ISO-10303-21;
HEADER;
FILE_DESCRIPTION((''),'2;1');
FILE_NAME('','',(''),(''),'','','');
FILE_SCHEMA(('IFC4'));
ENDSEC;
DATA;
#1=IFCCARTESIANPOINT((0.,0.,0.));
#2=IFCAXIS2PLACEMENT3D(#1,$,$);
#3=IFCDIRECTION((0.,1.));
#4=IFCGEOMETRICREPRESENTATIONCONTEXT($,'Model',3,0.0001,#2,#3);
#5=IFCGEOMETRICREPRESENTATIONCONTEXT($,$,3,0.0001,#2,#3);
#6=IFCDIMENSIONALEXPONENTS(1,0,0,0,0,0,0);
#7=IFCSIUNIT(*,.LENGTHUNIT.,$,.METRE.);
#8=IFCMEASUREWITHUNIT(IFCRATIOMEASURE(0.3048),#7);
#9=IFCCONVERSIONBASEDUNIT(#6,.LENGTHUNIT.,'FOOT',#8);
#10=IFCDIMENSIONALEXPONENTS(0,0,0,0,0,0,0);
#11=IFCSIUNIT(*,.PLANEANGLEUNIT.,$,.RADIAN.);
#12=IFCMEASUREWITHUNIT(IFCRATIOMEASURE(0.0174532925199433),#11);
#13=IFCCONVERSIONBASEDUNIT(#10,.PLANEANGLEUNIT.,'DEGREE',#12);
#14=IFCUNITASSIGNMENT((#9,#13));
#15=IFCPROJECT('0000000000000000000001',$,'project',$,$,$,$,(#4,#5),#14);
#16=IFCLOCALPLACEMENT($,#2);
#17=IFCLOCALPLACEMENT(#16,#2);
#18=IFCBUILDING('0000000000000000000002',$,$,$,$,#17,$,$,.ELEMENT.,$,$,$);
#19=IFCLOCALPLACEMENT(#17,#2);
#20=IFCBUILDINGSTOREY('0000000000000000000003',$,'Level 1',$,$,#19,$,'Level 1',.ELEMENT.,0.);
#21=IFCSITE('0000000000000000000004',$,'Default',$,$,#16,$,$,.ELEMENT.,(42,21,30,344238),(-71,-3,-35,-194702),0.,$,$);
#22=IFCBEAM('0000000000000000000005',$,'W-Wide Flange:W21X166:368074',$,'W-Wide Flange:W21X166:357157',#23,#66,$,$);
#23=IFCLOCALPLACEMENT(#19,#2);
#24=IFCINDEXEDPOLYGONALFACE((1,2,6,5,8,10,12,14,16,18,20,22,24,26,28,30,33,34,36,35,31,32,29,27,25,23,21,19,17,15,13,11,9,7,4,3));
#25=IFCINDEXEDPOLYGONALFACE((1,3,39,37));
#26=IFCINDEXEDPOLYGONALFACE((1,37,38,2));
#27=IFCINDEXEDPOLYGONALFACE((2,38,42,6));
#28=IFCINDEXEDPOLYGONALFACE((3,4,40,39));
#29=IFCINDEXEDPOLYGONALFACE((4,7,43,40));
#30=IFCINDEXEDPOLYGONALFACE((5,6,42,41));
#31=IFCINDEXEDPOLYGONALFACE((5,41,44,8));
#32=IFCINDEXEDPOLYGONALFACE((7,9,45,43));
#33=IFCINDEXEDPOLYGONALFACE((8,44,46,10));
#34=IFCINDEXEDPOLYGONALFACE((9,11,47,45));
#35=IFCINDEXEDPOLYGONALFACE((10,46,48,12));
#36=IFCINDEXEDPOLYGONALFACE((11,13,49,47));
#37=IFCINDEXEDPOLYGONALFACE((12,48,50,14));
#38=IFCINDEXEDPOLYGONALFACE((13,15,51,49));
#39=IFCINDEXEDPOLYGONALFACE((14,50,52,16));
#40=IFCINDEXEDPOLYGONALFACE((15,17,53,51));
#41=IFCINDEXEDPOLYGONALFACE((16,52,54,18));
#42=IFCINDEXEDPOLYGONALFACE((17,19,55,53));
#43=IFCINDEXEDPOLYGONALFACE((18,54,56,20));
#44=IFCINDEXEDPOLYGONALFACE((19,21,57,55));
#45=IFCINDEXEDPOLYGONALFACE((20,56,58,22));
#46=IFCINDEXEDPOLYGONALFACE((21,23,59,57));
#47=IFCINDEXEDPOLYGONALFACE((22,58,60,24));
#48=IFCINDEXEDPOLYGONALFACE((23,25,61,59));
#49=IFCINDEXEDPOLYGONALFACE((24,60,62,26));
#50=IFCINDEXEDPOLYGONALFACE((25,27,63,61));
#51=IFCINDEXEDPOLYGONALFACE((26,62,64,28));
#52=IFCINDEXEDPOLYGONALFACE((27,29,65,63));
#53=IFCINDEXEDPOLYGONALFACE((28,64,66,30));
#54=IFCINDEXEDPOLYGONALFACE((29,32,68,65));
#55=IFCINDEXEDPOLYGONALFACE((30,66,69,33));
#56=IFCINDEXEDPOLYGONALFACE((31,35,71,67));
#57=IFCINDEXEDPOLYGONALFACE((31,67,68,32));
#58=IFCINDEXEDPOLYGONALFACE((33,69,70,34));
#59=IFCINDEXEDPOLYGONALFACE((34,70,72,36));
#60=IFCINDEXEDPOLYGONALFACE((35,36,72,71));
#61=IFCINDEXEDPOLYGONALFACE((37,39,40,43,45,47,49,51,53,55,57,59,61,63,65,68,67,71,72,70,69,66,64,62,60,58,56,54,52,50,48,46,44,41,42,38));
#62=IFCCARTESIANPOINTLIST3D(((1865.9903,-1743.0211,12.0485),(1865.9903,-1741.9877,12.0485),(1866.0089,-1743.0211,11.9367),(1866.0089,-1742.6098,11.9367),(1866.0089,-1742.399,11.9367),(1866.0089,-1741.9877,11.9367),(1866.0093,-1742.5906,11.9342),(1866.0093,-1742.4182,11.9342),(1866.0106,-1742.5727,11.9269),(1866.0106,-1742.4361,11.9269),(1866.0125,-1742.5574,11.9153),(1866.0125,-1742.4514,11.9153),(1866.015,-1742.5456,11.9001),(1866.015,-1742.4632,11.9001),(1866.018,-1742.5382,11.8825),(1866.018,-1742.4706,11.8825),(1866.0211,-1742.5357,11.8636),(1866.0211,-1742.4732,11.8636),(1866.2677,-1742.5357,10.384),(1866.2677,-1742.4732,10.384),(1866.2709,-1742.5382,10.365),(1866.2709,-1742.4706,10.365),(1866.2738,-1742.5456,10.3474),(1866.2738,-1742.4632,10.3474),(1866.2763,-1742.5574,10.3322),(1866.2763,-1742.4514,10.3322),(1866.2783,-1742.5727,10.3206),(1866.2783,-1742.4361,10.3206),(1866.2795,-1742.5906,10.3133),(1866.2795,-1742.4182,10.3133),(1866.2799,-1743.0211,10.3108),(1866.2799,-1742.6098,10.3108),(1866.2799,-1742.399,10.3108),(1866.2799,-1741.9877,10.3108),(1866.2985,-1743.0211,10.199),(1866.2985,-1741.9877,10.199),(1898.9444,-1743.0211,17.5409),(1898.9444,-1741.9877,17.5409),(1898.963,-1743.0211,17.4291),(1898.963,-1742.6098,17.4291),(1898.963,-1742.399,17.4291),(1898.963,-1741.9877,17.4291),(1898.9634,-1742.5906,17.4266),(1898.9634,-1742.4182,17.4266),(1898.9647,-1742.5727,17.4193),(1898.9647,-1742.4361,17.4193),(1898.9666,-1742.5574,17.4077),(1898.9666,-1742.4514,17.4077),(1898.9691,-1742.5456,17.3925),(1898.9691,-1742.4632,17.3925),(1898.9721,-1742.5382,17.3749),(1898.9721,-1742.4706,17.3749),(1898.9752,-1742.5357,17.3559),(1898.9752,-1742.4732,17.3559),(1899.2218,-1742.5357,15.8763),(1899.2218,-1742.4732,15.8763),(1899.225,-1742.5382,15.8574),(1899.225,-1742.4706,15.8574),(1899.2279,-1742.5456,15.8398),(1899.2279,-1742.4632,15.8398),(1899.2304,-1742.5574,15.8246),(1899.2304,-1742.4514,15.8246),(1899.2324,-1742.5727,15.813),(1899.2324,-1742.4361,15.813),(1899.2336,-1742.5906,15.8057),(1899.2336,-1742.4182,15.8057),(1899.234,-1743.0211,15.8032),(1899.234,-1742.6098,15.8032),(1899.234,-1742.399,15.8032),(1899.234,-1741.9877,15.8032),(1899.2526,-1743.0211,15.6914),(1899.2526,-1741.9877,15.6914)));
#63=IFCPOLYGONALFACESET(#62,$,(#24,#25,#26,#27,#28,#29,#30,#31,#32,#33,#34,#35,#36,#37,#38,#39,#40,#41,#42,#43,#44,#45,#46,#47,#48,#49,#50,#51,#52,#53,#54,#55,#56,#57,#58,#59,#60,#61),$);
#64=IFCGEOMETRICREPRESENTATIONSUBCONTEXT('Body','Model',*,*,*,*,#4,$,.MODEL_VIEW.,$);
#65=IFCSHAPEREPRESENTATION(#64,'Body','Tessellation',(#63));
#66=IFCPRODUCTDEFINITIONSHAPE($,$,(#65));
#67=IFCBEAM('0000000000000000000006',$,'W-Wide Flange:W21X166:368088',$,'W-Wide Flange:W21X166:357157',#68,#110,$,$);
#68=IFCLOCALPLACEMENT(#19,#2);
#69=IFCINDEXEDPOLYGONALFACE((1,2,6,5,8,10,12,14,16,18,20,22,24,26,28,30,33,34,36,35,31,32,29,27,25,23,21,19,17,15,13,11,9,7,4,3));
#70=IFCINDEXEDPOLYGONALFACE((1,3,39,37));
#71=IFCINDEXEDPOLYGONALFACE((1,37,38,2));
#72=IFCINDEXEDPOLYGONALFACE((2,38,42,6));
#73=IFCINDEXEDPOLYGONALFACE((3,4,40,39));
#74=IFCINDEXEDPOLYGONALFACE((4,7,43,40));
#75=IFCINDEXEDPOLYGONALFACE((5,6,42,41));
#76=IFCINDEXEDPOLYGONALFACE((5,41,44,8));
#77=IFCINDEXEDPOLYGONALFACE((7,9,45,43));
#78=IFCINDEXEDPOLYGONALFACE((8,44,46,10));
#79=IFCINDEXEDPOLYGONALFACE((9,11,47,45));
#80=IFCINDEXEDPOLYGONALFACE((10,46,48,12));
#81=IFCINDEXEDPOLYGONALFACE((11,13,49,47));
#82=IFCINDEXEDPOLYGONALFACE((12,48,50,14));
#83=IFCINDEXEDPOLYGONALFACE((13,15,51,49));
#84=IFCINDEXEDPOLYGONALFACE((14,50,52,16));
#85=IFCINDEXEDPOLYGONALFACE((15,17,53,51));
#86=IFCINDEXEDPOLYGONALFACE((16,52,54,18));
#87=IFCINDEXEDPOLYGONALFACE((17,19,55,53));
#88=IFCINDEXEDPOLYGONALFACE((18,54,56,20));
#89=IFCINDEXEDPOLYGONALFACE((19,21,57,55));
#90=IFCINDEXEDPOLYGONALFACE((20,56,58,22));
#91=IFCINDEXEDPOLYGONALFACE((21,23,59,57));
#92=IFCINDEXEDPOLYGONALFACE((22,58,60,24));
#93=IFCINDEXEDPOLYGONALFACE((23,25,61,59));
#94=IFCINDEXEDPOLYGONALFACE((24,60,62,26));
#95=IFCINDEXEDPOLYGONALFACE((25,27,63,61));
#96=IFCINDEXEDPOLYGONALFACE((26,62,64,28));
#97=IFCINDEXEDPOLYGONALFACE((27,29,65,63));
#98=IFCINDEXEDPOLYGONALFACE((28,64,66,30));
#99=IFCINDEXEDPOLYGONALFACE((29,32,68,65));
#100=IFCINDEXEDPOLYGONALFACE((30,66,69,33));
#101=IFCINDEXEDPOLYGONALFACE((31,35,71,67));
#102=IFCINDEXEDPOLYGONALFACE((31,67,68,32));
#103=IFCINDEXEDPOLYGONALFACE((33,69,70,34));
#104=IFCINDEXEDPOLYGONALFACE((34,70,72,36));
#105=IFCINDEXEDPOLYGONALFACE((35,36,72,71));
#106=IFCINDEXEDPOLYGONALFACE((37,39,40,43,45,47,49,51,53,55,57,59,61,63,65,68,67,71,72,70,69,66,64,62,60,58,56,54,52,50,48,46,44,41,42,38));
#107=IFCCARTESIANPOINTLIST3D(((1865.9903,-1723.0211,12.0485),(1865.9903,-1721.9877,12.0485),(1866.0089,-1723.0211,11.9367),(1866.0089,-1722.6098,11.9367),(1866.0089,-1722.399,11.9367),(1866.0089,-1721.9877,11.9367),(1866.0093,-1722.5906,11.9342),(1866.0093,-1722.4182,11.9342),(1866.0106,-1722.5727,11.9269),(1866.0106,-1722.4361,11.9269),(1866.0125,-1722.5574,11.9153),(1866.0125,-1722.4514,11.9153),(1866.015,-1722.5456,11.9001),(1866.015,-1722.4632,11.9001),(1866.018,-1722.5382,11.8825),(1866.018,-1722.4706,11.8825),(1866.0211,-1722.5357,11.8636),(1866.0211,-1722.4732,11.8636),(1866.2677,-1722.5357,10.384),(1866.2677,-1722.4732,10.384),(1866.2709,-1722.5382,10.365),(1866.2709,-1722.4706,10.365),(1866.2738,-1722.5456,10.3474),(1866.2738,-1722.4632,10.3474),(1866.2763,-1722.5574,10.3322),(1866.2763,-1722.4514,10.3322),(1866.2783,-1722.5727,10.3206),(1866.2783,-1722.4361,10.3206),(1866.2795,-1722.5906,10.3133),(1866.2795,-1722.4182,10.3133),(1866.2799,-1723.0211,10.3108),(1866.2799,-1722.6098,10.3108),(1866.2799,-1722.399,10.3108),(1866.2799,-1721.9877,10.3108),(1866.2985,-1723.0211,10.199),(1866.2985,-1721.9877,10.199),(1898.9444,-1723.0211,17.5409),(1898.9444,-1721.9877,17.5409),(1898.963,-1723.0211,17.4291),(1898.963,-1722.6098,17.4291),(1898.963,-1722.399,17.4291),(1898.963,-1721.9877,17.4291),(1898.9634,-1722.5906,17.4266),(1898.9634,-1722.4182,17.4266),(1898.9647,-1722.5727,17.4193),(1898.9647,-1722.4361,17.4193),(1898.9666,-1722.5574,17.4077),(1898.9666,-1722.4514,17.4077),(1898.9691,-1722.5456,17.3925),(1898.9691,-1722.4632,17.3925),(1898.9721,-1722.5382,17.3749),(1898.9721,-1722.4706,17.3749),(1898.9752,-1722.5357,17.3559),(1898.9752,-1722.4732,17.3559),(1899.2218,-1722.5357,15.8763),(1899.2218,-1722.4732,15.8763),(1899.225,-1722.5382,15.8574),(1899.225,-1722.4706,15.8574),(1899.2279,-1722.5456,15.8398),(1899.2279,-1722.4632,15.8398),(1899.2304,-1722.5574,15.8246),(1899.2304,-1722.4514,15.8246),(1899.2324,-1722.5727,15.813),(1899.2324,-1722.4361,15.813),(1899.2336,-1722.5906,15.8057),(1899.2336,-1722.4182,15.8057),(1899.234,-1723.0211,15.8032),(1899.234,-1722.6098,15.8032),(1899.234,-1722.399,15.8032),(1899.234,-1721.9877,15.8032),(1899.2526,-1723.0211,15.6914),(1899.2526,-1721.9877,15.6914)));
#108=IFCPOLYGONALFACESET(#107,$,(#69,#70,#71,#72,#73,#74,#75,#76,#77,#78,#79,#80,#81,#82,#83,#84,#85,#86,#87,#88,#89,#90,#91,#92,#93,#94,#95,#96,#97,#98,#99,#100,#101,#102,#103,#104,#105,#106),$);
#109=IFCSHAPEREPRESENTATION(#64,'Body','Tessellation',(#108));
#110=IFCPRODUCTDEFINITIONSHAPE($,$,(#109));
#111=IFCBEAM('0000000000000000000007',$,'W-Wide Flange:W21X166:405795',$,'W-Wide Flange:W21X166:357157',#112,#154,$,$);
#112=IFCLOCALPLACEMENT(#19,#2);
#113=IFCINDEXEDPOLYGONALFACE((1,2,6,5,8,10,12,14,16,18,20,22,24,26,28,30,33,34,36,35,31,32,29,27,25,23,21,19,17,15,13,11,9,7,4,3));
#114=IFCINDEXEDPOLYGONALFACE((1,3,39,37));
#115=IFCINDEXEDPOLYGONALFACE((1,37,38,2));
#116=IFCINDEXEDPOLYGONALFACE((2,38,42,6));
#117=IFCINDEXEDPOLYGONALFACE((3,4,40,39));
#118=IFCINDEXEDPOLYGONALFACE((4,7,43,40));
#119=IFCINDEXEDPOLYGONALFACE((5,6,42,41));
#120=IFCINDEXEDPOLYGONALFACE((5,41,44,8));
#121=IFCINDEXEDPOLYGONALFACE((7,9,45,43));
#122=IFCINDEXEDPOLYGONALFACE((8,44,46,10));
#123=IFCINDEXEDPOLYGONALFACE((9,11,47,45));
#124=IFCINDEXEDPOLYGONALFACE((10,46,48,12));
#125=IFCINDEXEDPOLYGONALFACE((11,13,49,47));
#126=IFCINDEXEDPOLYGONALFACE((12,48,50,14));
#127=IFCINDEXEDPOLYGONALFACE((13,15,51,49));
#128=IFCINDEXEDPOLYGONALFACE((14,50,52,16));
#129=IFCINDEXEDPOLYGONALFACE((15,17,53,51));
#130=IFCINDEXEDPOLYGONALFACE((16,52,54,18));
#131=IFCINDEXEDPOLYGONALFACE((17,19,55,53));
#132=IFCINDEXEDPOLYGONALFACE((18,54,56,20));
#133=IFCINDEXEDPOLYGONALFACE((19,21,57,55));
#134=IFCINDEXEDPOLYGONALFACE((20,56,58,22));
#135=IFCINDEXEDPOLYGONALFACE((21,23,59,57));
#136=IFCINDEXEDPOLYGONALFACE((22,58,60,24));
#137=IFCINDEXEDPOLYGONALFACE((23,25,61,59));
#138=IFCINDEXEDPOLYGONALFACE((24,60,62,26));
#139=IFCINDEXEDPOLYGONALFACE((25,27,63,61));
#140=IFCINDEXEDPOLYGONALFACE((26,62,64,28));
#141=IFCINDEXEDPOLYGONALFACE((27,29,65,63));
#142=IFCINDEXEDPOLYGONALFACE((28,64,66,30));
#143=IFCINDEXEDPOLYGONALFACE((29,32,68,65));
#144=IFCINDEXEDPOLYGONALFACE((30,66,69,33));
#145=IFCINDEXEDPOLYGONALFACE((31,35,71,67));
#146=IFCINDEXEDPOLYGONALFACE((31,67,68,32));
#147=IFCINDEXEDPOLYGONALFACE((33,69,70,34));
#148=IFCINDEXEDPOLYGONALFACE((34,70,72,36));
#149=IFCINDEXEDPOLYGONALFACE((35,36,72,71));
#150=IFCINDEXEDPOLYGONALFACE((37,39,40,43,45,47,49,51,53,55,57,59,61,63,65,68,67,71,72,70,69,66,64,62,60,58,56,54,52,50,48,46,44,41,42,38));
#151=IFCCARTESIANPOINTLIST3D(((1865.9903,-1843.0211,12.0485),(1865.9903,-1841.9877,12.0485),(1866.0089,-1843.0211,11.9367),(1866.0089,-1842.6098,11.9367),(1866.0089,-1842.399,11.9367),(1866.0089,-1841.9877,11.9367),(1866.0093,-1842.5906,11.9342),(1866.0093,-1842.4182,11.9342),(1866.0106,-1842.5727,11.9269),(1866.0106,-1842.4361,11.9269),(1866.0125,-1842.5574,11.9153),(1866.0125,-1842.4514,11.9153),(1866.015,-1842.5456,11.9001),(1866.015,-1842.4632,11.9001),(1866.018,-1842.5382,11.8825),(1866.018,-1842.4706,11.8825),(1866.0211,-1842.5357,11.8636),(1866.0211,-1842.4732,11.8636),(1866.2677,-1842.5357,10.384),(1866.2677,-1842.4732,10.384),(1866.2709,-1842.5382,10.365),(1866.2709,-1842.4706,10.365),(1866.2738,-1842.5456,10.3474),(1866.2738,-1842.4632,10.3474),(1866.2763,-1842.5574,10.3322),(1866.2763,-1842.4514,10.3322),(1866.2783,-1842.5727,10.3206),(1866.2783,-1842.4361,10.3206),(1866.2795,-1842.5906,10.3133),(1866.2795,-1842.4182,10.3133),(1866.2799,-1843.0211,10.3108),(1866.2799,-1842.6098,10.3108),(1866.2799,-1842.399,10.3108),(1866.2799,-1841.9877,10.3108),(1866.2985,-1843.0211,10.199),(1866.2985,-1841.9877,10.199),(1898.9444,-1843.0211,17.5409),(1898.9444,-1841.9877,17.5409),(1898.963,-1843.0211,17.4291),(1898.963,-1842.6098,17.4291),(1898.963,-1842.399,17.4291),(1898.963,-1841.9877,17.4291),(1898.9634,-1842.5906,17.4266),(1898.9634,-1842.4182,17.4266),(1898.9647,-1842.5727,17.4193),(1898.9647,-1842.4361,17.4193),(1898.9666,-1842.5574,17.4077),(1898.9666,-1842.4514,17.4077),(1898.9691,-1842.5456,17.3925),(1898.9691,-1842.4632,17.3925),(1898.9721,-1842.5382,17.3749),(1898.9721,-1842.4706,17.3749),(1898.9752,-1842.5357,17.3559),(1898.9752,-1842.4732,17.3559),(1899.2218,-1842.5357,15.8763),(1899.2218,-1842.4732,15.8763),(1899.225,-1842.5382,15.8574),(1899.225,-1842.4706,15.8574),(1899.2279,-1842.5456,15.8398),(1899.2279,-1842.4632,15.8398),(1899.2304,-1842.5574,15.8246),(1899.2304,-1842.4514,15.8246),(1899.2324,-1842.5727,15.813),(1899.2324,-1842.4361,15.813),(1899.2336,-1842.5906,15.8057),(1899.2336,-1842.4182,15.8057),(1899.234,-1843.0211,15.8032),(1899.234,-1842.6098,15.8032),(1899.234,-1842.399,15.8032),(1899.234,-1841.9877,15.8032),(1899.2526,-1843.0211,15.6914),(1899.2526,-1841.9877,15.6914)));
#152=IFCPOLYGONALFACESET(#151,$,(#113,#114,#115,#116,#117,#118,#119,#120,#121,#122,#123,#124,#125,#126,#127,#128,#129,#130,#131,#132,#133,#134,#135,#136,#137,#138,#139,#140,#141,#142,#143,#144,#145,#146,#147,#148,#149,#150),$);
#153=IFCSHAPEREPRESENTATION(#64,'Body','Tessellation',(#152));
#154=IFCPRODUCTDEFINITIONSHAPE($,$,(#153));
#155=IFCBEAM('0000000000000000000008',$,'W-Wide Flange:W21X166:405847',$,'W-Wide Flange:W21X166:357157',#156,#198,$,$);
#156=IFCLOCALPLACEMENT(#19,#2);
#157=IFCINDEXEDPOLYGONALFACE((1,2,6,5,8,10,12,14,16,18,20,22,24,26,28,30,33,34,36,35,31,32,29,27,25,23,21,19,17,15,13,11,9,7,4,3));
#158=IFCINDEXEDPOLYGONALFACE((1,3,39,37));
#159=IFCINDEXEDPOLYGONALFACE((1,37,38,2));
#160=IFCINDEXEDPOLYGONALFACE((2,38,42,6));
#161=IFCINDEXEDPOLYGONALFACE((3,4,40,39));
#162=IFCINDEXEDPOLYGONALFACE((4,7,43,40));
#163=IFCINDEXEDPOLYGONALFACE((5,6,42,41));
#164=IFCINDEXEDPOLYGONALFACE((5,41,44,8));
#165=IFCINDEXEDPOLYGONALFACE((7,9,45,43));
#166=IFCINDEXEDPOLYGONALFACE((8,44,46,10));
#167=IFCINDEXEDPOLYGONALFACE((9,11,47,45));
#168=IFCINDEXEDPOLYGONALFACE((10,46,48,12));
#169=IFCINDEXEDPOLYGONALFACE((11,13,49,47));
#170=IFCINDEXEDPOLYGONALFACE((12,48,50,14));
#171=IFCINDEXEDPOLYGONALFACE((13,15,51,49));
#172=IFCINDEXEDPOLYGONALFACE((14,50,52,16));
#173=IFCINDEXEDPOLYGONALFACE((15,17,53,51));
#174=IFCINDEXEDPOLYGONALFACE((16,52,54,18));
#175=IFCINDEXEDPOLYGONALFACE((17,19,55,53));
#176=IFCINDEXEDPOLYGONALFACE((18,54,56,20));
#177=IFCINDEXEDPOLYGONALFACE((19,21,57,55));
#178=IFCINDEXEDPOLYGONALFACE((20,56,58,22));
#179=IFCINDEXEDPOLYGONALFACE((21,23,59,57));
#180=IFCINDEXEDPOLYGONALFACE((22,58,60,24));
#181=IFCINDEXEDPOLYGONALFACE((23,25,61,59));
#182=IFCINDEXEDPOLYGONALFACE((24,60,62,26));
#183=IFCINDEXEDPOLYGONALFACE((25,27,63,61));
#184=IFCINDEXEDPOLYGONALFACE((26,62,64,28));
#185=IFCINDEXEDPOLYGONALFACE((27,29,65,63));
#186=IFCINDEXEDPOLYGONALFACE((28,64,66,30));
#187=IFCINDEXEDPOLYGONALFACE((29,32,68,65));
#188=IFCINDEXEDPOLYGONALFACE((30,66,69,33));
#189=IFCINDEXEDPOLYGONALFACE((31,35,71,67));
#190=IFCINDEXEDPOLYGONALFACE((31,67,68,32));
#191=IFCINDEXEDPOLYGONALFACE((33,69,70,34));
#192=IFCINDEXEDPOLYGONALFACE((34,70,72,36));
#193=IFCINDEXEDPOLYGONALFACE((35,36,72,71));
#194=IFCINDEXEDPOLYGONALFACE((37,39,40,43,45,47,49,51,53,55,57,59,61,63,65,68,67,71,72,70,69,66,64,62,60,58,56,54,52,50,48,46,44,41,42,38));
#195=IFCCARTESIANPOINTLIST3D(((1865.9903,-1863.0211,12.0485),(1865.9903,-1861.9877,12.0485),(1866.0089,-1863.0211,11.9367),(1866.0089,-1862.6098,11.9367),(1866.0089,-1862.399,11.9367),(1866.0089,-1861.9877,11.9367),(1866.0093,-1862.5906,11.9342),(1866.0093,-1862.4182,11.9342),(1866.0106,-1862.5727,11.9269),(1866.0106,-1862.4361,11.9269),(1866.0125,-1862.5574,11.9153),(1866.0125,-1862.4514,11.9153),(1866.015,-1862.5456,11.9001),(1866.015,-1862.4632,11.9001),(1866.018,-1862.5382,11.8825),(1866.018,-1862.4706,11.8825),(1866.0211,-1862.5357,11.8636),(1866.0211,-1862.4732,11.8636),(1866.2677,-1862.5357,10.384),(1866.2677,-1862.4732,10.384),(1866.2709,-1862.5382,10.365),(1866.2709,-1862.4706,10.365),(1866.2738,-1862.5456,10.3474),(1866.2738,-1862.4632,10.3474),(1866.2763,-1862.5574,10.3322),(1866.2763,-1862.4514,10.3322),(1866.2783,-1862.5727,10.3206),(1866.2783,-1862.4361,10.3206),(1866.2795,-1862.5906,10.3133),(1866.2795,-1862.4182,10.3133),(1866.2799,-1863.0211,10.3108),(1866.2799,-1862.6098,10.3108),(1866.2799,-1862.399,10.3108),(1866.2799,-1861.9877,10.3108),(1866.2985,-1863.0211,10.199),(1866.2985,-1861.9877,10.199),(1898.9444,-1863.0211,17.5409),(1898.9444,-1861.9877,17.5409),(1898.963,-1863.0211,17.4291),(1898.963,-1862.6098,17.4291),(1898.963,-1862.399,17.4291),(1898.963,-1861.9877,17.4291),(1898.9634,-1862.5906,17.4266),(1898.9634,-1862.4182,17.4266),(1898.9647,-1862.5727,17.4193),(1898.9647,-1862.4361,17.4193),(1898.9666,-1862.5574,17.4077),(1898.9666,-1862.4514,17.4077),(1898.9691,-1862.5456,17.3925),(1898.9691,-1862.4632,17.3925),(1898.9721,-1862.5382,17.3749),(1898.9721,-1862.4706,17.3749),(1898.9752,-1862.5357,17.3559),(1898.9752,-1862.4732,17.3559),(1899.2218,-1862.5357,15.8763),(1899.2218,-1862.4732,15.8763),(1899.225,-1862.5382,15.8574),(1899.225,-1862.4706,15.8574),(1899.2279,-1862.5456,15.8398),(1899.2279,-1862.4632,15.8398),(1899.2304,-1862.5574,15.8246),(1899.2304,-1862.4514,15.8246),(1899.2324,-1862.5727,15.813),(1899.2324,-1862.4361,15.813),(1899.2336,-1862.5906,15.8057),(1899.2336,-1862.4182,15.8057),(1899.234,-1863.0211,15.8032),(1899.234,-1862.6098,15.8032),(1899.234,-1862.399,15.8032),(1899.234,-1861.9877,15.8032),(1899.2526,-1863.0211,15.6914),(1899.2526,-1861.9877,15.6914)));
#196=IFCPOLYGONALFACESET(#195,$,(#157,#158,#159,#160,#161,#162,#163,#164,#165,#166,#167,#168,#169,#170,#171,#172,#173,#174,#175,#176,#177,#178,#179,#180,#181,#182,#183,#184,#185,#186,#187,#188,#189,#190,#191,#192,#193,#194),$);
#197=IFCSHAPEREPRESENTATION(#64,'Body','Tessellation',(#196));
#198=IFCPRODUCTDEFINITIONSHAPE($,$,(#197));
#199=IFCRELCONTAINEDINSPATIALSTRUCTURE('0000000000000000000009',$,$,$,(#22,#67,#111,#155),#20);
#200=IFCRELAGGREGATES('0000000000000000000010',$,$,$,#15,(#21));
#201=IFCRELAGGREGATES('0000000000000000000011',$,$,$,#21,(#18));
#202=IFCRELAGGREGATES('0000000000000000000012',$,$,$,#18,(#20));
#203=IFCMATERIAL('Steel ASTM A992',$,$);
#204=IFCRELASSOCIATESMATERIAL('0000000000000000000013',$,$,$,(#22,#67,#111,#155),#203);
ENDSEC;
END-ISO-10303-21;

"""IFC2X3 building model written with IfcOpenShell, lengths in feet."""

from ifc_helpers import new_model, entity, si_unit, converted_unit, direction, frame, frame_2d, origin, place, context, subcontext, project, spatial, i_section, extrude, material, element, save


model = new_model("IFC2X3")

# Units and contexts
model_context = context("Model", 3, precision=0.0001, world=origin(), true_north=direction((0.0, 1.0)))
context_of_model = context(None, 3, precision=0.0001, world=origin(), true_north=direction((0.0, 1.0)))
body_context = subcontext(model_context, "Body", "Model", "MODEL_VIEW")
ifc_project = project(units=[converted_unit("LENGTHUNIT", "FOOT", entity("IfcRatioMeasure", 0.3048), si_unit("LENGTHUNIT", "METRE"), dimensions=[1, 0, 0, 0, 0, 0, 0]), converted_unit("PLANEANGLEUNIT", "DEGREE", entity("IfcRatioMeasure", 0.0174532925199433), si_unit("PLANEANGLEUNIT", "RADIAN"), dimensions=[0, 0, 0, 0, 0, 0, 0])], contexts=[model_context, context_of_model])

# Site, building, storey
site_placement = place(None, origin())
site = spatial("IfcSite", under=ifc_project, at=site_placement, Name="Default", CompositionType="ELEMENT", RefLatitude=(42, 21, 30, 344238), RefLongitude=(-71, -3, -35, -194702), RefElevation=0.0)
building_placement = place(site_placement, origin())
building = spatial("IfcBuilding", under=site, at=building_placement, CompositionType="ELEMENT")
storey_placement = place(building_placement, origin())
storey = spatial("IfcBuildingStorey", under=building, at=storey_placement, Name="Level 1", LongName="Level 1", CompositionType="ELEMENT", Elevation=0.0)

# Shared definitions
ifc_material_1 = material(Name="Steel ASTM A992")

# Beams
beam_1_placement = place(storey_placement, frame((1865.8276, -1742.5044, 12.0214), z_axis=(-0.164399, 0.0, 0.986394), x_axis=(0.986394, 0.0, 0.164399)))
element("IfcBeam", 1, at=beam_1_placement, inside=storey, material=ifc_material_1, Name="W-Wide Flange:W21X166:368074", ObjectType="W-Wide Flange:W21X166:357157", context=body_context, shape_type="SweptSolid", body=[
    extrude(i_section(OverallWidth=1.0333, OverallDepth=1.875, WebThickness=0.0625, FlangeThickness=0.1133, FilletRadius=0.0742, at=frame_2d((0.0, 0.0), x_axis=(0.0, 1.0))), frame((0.165, 0.0, -0.9375), z_axis=(1.0, 0.0, 0.0), x_axis=(0.0, 0.0, -1.0)), (0.0, 0.0, 1.0), 33.4087),
])
beam_2_placement = place(storey_placement, frame((1865.8276, -1722.5044, 12.0214), z_axis=(-0.164399, 0.0, 0.986394), x_axis=(0.986394, 0.0, 0.164399)))
element("IfcBeam", 2, at=beam_2_placement, inside=storey, material=ifc_material_1, Name="W-Wide Flange:W21X166:368088", ObjectType="W-Wide Flange:W21X166:357157", context=body_context, shape_type="SweptSolid", body=[
    extrude(i_section(OverallWidth=1.0333, OverallDepth=1.875, WebThickness=0.0625, FlangeThickness=0.1133, FilletRadius=0.0742, at=frame_2d((0.0, 0.0), x_axis=(0.0, 1.0))), frame((0.165, 0.0, -0.9375), z_axis=(1.0, 0.0, 0.0), x_axis=(0.0, 0.0, -1.0)), (0.0, 0.0, 1.0), 33.4087),
])
beam_3_placement = place(storey_placement, frame((1865.8276, -1842.5044, 12.0214), z_axis=(-0.164399, 0.0, 0.986394), x_axis=(0.986394, 0.0, 0.164399)))
element("IfcBeam", 3, at=beam_3_placement, inside=storey, material=ifc_material_1, Name="W-Wide Flange:W21X166:405795", ObjectType="W-Wide Flange:W21X166:357157", context=body_context, shape_type="SweptSolid", body=[
    extrude(i_section(OverallWidth=1.0333, OverallDepth=1.875, WebThickness=0.0625, FlangeThickness=0.1133, FilletRadius=0.0742, at=frame_2d((0.0, 0.0), x_axis=(0.0, 1.0))), frame((0.165, 0.0, -0.9375), z_axis=(1.0, 0.0, 0.0), x_axis=(0.0, 0.0, -1.0)), (0.0, 0.0, 1.0), 33.4087),
])
beam_4_placement = place(storey_placement, frame((1865.8276, -1862.5044, 12.0214), z_axis=(-0.164399, 0.0, 0.986394), x_axis=(0.986394, 0.0, 0.164399)))
element("IfcBeam", 4, at=beam_4_placement, inside=storey, material=ifc_material_1, Name="W-Wide Flange:W21X166:405847", ObjectType="W-Wide Flange:W21X166:357157", context=body_context, shape_type="SweptSolid", body=[
    extrude(i_section(OverallWidth=1.0333, OverallDepth=1.875, WebThickness=0.0625, FlangeThickness=0.1133, FilletRadius=0.0742, at=frame_2d((0.0, 0.0), x_axis=(0.0, 1.0))), frame((0.165, 0.0, -0.9375), z_axis=(1.0, 0.0, 0.0), x_axis=(0.0, 0.0, -1.0)), (0.0, 0.0, 1.0), 33.4087),
])

save(model, "model.ifc")
